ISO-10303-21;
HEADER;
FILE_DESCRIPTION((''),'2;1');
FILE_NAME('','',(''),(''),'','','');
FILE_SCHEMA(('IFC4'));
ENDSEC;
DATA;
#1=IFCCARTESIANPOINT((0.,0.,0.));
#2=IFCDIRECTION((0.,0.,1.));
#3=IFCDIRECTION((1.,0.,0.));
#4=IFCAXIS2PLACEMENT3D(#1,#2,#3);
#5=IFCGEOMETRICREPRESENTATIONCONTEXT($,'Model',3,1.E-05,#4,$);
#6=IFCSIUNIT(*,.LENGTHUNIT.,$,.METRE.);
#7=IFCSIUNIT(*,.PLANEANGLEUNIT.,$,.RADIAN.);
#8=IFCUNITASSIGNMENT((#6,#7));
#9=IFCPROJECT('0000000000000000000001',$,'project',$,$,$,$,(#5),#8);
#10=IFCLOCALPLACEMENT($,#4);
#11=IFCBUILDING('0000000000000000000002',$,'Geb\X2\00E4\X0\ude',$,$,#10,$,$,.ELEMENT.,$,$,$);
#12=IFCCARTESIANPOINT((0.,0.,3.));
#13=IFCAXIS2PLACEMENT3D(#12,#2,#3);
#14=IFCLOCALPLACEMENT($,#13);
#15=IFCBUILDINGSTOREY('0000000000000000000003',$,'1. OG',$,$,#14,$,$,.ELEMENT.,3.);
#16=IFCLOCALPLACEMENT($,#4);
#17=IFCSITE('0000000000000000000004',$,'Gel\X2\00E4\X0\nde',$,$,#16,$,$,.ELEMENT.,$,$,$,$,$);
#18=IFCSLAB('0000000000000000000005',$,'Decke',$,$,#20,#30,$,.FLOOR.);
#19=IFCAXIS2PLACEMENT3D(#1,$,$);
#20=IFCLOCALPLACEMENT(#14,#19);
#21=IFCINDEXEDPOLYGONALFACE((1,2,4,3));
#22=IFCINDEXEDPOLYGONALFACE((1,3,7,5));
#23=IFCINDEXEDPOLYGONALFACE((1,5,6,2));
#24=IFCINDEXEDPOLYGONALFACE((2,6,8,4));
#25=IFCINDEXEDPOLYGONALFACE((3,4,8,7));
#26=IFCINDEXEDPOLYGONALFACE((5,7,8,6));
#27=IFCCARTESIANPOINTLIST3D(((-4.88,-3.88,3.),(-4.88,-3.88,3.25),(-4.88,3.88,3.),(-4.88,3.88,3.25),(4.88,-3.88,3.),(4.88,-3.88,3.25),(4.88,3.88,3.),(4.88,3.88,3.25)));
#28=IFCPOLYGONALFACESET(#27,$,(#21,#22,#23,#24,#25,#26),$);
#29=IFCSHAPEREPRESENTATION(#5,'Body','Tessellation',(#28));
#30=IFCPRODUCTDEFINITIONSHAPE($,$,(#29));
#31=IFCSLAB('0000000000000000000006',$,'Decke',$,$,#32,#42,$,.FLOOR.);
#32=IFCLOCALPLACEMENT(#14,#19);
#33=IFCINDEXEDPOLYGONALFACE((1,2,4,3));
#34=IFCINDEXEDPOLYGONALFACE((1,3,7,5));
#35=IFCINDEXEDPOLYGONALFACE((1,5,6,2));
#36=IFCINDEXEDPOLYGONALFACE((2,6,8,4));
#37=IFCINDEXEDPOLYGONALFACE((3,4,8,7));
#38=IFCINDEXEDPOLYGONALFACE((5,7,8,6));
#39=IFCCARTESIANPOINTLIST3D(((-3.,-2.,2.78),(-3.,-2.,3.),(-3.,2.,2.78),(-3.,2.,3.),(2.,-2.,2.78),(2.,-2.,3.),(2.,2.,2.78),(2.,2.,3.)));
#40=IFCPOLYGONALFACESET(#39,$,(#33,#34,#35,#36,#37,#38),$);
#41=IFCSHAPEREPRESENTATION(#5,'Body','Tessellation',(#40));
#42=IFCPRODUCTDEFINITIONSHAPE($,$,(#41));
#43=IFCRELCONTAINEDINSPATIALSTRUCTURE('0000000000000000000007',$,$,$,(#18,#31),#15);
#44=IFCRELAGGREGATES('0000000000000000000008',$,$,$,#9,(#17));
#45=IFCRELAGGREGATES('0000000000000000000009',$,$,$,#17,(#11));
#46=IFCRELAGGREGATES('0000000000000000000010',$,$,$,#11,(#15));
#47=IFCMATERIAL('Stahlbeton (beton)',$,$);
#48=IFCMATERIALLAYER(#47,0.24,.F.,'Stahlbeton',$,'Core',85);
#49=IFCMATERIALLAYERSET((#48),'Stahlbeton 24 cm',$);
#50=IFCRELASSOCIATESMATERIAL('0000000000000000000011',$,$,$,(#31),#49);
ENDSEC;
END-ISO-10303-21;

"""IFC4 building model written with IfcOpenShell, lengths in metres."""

from ifc_helpers import new_model, si_unit, frame, origin_with_axes, place, context, project, spatial, polyline, outline, extrude, material, layer, layer_set, element, save


model = new_model("IFC4")

# Units and contexts
model_context = context("Model", 3, precision=1e-05, world=origin_with_axes())
ifc_project = project(units=[si_unit("LENGTHUNIT", "METRE"), si_unit("PLANEANGLEUNIT", "RADIAN")], contexts=[model_context])

# Site, building, storey
site_placement = place(None, origin_with_axes())
site = spatial("IfcSite", under=ifc_project, at=site_placement, Name="Gelände", CompositionType="ELEMENT")
building_placement = place(None, origin_with_axes())
building = spatial("IfcBuilding", under=site, at=building_placement, Name="Gebäude", CompositionType="ELEMENT")
storey_placement = place(None, frame((0.0, 0.0, 3.0), z_axis=(0.0, 0.0, 1.0), x_axis=(1.0, 0.0, 0.0)))
storey = spatial("IfcBuildingStorey", under=building, at=storey_placement, Name="1. OG", CompositionType="ELEMENT", Elevation=3.0)

# Slabs
slab_1_placement = place(None, frame((0.0, 0.0, 6.0), z_axis=(0.0, 0.0, 1.0), x_axis=(1.0, 0.0, 0.0)))
element("IfcSlab", 1, at=slab_1_placement, inside=storey, Name="Decke", PredefinedType="FLOOR", context=model_context, shape_type="SweptSolid", body=[
    extrude(outline(polyline([(-4.88, -3.88), (4.88, -3.88), (4.88, 3.88), (-4.88, 3.88), (-4.88, -3.88)])), origin_with_axes(), (0.0, 0.0, 1.0), 0.25),
])
ifc_material_1 = material(Name="Stahlbeton (beton)")
ifc_layer_1 = layer(ifc_material_1, 0.24, ventilated=False, Name="Stahlbeton", Category="Core", Priority=85)
ifc_layer_set_1 = layer_set([ifc_layer_1], Name="Stahlbeton 24 cm")
slab_2_placement = place(None, frame((0.0, 0.0, 5.78), z_axis=(0.0, 0.0, 1.0), x_axis=(1.0, 0.0, 0.0)))
element("IfcSlab", 2, at=slab_2_placement, inside=storey, material=ifc_layer_set_1, Name="Decke", PredefinedType="FLOOR", context=model_context, shape_type="SweptSolid", body=[
    extrude(outline(polyline([(-3.0, -2.0), (2.0, -2.0), (2.0, 2.0), (-3.0, 2.0), (-3.0, -2.0)])), origin_with_axes(), (0.0, 0.0, 1.0), 0.22),
])

save(model, "model.ifc")
